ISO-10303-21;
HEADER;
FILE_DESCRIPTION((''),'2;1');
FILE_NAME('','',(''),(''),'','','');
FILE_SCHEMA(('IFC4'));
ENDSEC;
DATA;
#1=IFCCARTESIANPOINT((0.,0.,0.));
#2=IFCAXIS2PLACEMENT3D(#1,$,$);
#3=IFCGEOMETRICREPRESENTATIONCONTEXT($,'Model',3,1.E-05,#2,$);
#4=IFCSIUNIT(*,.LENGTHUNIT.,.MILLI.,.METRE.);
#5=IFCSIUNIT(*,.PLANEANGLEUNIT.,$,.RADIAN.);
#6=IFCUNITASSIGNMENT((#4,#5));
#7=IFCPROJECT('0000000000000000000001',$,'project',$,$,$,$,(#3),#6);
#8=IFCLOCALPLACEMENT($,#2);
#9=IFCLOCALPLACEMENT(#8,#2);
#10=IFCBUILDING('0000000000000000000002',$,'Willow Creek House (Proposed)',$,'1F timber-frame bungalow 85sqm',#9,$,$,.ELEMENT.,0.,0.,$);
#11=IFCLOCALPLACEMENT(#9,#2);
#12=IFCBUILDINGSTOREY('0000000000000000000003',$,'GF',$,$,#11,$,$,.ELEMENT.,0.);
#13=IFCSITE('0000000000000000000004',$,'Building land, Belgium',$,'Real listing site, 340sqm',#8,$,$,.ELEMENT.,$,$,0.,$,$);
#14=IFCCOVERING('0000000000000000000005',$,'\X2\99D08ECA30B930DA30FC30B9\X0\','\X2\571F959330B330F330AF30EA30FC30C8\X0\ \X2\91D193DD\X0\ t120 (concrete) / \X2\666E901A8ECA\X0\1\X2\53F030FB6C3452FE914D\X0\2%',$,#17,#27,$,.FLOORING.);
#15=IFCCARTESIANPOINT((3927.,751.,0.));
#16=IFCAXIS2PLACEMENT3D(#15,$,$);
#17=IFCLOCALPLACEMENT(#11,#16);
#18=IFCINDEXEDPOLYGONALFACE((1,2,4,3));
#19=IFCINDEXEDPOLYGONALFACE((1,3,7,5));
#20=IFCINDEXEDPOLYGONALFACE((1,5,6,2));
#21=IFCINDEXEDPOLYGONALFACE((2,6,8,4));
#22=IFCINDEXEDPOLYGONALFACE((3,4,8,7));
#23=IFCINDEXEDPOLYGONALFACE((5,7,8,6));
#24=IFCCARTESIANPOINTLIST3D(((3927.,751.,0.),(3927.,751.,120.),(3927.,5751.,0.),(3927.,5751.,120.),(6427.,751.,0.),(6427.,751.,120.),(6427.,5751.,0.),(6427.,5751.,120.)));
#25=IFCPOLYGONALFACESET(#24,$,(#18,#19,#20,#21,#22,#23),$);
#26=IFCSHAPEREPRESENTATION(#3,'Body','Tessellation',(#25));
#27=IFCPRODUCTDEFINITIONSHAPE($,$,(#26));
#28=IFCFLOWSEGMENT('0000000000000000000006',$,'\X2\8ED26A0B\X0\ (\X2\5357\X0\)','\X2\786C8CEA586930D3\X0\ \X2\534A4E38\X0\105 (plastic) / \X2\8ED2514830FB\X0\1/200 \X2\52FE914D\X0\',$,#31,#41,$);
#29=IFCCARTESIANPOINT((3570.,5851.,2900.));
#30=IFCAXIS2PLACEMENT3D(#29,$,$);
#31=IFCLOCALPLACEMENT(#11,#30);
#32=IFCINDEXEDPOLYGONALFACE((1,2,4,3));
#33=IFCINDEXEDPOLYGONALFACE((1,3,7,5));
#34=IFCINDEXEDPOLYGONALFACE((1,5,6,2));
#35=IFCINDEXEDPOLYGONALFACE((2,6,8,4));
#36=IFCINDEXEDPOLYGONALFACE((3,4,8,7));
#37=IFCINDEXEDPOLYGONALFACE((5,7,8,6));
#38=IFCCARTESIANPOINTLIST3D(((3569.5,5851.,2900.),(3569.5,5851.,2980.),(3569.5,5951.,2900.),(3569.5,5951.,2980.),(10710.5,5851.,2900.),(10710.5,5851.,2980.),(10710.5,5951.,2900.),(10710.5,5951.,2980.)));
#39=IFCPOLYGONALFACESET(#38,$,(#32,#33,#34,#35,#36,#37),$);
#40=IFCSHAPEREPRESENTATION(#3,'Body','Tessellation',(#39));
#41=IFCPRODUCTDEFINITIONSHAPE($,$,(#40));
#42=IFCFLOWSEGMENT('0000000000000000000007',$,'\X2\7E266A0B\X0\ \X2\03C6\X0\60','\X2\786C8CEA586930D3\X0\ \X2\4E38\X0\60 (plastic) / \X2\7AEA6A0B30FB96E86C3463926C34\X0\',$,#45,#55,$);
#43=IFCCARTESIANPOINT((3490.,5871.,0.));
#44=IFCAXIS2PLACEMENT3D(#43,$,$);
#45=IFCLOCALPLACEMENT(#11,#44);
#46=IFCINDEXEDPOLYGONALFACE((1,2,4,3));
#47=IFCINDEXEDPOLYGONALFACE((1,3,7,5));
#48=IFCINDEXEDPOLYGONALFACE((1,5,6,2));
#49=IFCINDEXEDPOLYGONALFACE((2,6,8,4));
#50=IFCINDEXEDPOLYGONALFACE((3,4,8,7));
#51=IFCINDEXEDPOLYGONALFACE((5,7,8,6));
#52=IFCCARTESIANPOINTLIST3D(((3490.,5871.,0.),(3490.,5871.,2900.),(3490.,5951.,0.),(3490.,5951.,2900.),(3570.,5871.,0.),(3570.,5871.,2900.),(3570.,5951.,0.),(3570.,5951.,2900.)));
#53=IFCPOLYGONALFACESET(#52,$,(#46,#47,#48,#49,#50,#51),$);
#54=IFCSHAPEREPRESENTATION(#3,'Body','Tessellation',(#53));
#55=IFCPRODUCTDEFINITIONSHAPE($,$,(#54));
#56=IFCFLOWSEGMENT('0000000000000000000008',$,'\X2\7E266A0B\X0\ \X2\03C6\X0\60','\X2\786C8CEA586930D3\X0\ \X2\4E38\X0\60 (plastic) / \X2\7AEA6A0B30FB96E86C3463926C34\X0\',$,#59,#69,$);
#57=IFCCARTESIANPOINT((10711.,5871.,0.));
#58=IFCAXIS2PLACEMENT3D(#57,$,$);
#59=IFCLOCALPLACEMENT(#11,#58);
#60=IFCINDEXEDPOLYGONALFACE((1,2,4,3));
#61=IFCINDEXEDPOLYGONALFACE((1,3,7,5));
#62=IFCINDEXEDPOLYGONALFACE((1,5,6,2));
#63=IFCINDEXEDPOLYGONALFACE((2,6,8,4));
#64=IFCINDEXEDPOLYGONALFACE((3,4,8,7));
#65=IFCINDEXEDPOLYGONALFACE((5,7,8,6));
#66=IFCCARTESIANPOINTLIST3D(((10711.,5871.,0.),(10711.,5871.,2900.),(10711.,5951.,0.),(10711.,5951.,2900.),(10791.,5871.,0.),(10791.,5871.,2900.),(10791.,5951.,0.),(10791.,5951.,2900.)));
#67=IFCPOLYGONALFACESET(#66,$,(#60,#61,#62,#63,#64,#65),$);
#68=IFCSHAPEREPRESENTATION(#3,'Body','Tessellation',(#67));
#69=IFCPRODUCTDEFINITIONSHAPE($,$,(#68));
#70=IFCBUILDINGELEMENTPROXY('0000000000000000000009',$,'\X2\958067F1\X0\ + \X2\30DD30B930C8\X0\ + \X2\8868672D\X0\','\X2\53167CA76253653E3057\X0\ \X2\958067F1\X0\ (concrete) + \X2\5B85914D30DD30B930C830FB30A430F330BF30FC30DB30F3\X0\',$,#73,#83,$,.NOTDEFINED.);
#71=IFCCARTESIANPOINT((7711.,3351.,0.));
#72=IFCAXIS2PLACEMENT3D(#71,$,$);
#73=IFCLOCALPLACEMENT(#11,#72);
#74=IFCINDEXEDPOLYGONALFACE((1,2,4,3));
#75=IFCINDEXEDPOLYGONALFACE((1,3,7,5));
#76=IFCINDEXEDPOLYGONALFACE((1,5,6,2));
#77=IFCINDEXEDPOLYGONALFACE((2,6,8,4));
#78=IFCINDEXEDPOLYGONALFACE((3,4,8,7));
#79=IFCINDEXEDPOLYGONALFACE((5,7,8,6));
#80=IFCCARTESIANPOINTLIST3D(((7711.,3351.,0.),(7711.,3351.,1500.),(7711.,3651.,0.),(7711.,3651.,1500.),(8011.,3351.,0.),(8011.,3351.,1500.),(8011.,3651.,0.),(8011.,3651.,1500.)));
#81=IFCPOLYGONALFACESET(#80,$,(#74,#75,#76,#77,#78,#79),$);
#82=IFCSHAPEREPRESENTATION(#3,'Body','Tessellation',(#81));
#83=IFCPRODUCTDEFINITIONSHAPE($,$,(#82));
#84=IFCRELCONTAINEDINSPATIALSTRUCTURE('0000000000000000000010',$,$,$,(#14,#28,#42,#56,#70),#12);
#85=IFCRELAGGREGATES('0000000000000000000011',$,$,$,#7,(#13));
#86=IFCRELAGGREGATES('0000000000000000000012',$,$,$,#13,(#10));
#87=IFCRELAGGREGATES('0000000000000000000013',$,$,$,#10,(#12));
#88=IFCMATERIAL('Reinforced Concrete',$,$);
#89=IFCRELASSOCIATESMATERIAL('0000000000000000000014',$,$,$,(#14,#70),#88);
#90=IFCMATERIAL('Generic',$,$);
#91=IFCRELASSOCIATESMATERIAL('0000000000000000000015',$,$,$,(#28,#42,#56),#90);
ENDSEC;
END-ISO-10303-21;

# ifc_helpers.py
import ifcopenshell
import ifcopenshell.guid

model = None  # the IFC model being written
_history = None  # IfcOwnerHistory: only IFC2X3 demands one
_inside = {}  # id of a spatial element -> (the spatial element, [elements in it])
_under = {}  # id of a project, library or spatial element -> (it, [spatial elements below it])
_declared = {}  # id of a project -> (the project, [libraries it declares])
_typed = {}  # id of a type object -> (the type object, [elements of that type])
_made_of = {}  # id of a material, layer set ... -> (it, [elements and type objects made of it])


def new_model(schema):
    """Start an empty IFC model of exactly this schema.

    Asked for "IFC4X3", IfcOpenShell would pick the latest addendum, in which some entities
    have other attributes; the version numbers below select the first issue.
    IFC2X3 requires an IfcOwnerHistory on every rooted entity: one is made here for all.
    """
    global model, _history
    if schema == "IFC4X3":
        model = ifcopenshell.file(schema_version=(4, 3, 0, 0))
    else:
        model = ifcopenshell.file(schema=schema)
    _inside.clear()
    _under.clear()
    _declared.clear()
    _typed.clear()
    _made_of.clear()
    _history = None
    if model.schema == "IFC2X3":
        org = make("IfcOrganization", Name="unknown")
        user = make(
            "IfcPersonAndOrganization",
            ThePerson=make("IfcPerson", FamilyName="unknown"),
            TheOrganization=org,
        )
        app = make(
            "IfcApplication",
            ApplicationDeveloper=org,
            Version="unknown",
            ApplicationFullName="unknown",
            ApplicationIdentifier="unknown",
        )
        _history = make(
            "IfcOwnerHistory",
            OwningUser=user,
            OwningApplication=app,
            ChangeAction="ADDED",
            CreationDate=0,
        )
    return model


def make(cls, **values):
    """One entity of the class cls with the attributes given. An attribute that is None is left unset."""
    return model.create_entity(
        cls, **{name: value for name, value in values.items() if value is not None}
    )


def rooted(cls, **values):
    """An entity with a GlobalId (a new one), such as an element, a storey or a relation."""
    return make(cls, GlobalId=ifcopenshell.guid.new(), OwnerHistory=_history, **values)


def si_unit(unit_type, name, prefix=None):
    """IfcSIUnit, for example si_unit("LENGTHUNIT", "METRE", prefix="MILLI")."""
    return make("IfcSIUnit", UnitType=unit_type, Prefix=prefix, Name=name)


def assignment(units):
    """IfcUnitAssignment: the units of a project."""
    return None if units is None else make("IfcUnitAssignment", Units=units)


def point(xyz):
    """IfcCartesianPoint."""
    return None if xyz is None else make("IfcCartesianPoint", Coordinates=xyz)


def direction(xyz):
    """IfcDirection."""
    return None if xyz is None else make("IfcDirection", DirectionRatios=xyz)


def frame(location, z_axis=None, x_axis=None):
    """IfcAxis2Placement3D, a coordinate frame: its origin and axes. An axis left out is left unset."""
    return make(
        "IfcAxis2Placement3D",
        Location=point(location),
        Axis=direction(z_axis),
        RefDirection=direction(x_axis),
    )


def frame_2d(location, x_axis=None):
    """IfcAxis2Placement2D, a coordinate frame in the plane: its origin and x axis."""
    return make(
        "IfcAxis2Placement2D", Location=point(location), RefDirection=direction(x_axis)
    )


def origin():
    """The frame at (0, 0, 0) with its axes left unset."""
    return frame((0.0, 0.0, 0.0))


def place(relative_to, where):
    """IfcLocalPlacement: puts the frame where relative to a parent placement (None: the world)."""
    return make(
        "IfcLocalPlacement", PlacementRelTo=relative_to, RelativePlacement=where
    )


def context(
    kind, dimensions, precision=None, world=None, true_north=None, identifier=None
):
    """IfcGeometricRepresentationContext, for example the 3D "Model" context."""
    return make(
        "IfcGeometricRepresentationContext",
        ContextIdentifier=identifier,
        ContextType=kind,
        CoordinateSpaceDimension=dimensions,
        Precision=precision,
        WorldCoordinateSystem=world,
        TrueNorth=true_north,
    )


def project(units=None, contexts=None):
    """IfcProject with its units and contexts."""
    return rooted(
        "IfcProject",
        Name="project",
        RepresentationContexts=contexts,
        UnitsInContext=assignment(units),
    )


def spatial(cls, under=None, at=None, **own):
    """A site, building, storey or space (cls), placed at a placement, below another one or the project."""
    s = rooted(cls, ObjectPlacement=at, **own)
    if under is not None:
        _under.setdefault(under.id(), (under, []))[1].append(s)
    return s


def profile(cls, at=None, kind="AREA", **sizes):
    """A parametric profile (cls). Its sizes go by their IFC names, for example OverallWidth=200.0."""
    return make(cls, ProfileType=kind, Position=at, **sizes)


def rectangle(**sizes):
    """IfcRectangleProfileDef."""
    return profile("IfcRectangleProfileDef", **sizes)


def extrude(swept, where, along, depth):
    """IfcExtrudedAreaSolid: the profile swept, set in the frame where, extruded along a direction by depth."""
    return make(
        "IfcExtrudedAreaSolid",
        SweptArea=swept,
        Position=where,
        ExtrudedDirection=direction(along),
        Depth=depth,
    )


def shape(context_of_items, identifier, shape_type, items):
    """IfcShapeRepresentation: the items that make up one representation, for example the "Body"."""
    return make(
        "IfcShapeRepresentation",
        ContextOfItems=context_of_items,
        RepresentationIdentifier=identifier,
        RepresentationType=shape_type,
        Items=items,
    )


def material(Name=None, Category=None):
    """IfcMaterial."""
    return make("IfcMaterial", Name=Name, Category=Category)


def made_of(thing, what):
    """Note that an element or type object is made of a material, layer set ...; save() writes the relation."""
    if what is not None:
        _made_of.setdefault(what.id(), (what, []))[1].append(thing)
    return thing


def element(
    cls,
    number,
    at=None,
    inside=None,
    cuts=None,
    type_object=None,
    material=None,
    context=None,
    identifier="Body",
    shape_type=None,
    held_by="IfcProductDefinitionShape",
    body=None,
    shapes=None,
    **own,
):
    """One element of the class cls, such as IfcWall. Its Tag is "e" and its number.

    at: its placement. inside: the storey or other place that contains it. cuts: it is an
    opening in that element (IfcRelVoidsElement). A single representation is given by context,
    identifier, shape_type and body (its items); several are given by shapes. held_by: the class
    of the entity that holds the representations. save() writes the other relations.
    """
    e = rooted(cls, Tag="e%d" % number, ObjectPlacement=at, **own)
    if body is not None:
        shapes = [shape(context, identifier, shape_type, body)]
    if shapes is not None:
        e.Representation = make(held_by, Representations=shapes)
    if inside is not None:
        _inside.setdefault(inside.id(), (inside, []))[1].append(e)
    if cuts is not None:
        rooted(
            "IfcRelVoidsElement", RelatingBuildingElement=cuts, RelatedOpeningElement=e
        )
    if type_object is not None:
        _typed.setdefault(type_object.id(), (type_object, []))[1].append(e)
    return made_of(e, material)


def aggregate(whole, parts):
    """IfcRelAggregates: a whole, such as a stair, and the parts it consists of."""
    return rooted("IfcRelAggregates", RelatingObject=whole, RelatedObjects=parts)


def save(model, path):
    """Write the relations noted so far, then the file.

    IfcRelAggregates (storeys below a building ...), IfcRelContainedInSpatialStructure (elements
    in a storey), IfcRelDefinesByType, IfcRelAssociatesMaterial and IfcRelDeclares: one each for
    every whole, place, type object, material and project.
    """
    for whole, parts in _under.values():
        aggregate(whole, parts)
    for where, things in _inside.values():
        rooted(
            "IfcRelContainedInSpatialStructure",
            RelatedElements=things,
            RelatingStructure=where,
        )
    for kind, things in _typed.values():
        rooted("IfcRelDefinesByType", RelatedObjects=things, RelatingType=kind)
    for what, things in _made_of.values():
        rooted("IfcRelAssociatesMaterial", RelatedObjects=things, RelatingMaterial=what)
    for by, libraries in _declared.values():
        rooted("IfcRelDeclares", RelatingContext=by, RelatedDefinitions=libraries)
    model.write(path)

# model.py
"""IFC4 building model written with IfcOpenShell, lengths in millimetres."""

from ifc_helpers import new_model, si_unit, frame, frame_2d, origin, place, context, project, spatial, rectangle, extrude, material, element, save


model = new_model("IFC4")

# Units and contexts
model_context = context("Model", 3, precision=1e-05, world=origin())
ifc_project = project(units=[si_unit("LENGTHUNIT", "METRE", prefix="MILLI"), si_unit("PLANEANGLEUNIT", "RADIAN")], contexts=[model_context])

# Site, building, storey
site_placement = place(None, origin())
site = spatial("IfcSite", under=ifc_project, at=site_placement, Name="Building land, Belgium", ObjectType="Real listing site, 340sqm", CompositionType="ELEMENT", RefElevation=0.0)
building_placement = place(site_placement, origin())
building = spatial("IfcBuilding", under=site, at=building_placement, Name="Willow Creek House (Proposed)", ObjectType="1F timber-frame bungalow 85sqm", CompositionType="ELEMENT", ElevationOfRefHeight=0.0, ElevationOfTerrain=0.0)
storey_placement = place(building_placement, origin())
storey = spatial("IfcBuildingStorey", under=building, at=storey_placement, Name="GF", CompositionType="ELEMENT", Elevation=0.0)

# Shared definitions
ifc_material_1 = material(Name="Reinforced Concrete")

# Covering
covering_1_placement = place(storey_placement, frame((3927.0, 751.0, 0.0)))
element("IfcCovering", 1, at=covering_1_placement, inside=storey, material=ifc_material_1, Name="駐車スペース", Description="土間コンクリート 金鏝 t120 (concrete) / 普通車1台・水勾配2%", PredefinedType="FLOORING", context=model_context, shape_type="SweptSolid", body=[
    extrude(rectangle(XDim=2500.0, YDim=5000.0, at=frame_2d((1250.0, 2500.0))), frame((3927.0, 751.0, 0.0)), (0.0, 0.0, 1.0), 120.0),
])

# Flow segments
ifc_material_2 = material(Name="Generic")
flow_segment_1_placement = place(storey_placement, frame((3570.0, 5851.0, 2900.0)))
element("IfcFlowSegment", 2, at=flow_segment_1_placement, inside=storey, material=ifc_material_2, Name="軒樋 (南)", Description="硬質塩ビ 半丸105 (plastic) / 軒先・1/200 勾配", context=model_context, shape_type="SweptSolid", body=[
    extrude(rectangle(XDim=7141.0, YDim=100.0, at=frame_2d((3570.0, 50.0))), frame((3570.0, 5851.0, 2900.0)), (0.0, 0.0, 1.0), 80.0),
])
flow_segment_2_placement = place(storey_placement, frame((3490.0, 5871.0, 0.0)))
element("IfcFlowSegment", 3, at=flow_segment_2_placement, inside=storey, material=ifc_material_2, Name="縦樋 φ60", Description="硬質塩ビ 丸60 (plastic) / 竪樋・雨水排水", context=model_context, shape_type="SweptSolid", body=[
    extrude(rectangle(XDim=80.0, YDim=80.0, at=frame_2d((40.0, 40.0))), frame((3490.0, 5871.0, 0.0)), (0.0, 0.0, 1.0), 2900.0),
])
flow_segment_3_placement = place(storey_placement, frame((10711.0, 5871.0, 0.0)))
element("IfcFlowSegment", 4, at=flow_segment_3_placement, inside=storey, material=ifc_material_2, Name="縦樋 φ60", Description="硬質塩ビ 丸60 (plastic) / 竪樋・雨水排水", context=model_context, shape_type="SweptSolid", body=[
    extrude(rectangle(XDim=80.0, YDim=80.0, at=frame_2d((40.0, 40.0))), frame((10711.0, 5871.0, 0.0)), (0.0, 0.0, 1.0), 2900.0),
])

# Building element proxy
proxy_placement = place(storey_placement, frame((7711.0, 3351.0, 0.0)))
element("IfcBuildingElementProxy", 5, at=proxy_placement, inside=storey, material=ifc_material_1, Name="門柱 + ポスト + 表札", Description="化粧打放し 門柱 (concrete) + 宅配ポスト・インターホン", PredefinedType="NOTDEFINED", context=model_context, shape_type="SweptSolid", body=[
    extrude(rectangle(XDim=300.0, YDim=300.0, at=frame_2d((150.0, 150.0))), frame((7711.0, 3351.0, 0.0)), (0.0, 0.0, 1.0), 1500.0),
])

save(model, "model.ifc")
